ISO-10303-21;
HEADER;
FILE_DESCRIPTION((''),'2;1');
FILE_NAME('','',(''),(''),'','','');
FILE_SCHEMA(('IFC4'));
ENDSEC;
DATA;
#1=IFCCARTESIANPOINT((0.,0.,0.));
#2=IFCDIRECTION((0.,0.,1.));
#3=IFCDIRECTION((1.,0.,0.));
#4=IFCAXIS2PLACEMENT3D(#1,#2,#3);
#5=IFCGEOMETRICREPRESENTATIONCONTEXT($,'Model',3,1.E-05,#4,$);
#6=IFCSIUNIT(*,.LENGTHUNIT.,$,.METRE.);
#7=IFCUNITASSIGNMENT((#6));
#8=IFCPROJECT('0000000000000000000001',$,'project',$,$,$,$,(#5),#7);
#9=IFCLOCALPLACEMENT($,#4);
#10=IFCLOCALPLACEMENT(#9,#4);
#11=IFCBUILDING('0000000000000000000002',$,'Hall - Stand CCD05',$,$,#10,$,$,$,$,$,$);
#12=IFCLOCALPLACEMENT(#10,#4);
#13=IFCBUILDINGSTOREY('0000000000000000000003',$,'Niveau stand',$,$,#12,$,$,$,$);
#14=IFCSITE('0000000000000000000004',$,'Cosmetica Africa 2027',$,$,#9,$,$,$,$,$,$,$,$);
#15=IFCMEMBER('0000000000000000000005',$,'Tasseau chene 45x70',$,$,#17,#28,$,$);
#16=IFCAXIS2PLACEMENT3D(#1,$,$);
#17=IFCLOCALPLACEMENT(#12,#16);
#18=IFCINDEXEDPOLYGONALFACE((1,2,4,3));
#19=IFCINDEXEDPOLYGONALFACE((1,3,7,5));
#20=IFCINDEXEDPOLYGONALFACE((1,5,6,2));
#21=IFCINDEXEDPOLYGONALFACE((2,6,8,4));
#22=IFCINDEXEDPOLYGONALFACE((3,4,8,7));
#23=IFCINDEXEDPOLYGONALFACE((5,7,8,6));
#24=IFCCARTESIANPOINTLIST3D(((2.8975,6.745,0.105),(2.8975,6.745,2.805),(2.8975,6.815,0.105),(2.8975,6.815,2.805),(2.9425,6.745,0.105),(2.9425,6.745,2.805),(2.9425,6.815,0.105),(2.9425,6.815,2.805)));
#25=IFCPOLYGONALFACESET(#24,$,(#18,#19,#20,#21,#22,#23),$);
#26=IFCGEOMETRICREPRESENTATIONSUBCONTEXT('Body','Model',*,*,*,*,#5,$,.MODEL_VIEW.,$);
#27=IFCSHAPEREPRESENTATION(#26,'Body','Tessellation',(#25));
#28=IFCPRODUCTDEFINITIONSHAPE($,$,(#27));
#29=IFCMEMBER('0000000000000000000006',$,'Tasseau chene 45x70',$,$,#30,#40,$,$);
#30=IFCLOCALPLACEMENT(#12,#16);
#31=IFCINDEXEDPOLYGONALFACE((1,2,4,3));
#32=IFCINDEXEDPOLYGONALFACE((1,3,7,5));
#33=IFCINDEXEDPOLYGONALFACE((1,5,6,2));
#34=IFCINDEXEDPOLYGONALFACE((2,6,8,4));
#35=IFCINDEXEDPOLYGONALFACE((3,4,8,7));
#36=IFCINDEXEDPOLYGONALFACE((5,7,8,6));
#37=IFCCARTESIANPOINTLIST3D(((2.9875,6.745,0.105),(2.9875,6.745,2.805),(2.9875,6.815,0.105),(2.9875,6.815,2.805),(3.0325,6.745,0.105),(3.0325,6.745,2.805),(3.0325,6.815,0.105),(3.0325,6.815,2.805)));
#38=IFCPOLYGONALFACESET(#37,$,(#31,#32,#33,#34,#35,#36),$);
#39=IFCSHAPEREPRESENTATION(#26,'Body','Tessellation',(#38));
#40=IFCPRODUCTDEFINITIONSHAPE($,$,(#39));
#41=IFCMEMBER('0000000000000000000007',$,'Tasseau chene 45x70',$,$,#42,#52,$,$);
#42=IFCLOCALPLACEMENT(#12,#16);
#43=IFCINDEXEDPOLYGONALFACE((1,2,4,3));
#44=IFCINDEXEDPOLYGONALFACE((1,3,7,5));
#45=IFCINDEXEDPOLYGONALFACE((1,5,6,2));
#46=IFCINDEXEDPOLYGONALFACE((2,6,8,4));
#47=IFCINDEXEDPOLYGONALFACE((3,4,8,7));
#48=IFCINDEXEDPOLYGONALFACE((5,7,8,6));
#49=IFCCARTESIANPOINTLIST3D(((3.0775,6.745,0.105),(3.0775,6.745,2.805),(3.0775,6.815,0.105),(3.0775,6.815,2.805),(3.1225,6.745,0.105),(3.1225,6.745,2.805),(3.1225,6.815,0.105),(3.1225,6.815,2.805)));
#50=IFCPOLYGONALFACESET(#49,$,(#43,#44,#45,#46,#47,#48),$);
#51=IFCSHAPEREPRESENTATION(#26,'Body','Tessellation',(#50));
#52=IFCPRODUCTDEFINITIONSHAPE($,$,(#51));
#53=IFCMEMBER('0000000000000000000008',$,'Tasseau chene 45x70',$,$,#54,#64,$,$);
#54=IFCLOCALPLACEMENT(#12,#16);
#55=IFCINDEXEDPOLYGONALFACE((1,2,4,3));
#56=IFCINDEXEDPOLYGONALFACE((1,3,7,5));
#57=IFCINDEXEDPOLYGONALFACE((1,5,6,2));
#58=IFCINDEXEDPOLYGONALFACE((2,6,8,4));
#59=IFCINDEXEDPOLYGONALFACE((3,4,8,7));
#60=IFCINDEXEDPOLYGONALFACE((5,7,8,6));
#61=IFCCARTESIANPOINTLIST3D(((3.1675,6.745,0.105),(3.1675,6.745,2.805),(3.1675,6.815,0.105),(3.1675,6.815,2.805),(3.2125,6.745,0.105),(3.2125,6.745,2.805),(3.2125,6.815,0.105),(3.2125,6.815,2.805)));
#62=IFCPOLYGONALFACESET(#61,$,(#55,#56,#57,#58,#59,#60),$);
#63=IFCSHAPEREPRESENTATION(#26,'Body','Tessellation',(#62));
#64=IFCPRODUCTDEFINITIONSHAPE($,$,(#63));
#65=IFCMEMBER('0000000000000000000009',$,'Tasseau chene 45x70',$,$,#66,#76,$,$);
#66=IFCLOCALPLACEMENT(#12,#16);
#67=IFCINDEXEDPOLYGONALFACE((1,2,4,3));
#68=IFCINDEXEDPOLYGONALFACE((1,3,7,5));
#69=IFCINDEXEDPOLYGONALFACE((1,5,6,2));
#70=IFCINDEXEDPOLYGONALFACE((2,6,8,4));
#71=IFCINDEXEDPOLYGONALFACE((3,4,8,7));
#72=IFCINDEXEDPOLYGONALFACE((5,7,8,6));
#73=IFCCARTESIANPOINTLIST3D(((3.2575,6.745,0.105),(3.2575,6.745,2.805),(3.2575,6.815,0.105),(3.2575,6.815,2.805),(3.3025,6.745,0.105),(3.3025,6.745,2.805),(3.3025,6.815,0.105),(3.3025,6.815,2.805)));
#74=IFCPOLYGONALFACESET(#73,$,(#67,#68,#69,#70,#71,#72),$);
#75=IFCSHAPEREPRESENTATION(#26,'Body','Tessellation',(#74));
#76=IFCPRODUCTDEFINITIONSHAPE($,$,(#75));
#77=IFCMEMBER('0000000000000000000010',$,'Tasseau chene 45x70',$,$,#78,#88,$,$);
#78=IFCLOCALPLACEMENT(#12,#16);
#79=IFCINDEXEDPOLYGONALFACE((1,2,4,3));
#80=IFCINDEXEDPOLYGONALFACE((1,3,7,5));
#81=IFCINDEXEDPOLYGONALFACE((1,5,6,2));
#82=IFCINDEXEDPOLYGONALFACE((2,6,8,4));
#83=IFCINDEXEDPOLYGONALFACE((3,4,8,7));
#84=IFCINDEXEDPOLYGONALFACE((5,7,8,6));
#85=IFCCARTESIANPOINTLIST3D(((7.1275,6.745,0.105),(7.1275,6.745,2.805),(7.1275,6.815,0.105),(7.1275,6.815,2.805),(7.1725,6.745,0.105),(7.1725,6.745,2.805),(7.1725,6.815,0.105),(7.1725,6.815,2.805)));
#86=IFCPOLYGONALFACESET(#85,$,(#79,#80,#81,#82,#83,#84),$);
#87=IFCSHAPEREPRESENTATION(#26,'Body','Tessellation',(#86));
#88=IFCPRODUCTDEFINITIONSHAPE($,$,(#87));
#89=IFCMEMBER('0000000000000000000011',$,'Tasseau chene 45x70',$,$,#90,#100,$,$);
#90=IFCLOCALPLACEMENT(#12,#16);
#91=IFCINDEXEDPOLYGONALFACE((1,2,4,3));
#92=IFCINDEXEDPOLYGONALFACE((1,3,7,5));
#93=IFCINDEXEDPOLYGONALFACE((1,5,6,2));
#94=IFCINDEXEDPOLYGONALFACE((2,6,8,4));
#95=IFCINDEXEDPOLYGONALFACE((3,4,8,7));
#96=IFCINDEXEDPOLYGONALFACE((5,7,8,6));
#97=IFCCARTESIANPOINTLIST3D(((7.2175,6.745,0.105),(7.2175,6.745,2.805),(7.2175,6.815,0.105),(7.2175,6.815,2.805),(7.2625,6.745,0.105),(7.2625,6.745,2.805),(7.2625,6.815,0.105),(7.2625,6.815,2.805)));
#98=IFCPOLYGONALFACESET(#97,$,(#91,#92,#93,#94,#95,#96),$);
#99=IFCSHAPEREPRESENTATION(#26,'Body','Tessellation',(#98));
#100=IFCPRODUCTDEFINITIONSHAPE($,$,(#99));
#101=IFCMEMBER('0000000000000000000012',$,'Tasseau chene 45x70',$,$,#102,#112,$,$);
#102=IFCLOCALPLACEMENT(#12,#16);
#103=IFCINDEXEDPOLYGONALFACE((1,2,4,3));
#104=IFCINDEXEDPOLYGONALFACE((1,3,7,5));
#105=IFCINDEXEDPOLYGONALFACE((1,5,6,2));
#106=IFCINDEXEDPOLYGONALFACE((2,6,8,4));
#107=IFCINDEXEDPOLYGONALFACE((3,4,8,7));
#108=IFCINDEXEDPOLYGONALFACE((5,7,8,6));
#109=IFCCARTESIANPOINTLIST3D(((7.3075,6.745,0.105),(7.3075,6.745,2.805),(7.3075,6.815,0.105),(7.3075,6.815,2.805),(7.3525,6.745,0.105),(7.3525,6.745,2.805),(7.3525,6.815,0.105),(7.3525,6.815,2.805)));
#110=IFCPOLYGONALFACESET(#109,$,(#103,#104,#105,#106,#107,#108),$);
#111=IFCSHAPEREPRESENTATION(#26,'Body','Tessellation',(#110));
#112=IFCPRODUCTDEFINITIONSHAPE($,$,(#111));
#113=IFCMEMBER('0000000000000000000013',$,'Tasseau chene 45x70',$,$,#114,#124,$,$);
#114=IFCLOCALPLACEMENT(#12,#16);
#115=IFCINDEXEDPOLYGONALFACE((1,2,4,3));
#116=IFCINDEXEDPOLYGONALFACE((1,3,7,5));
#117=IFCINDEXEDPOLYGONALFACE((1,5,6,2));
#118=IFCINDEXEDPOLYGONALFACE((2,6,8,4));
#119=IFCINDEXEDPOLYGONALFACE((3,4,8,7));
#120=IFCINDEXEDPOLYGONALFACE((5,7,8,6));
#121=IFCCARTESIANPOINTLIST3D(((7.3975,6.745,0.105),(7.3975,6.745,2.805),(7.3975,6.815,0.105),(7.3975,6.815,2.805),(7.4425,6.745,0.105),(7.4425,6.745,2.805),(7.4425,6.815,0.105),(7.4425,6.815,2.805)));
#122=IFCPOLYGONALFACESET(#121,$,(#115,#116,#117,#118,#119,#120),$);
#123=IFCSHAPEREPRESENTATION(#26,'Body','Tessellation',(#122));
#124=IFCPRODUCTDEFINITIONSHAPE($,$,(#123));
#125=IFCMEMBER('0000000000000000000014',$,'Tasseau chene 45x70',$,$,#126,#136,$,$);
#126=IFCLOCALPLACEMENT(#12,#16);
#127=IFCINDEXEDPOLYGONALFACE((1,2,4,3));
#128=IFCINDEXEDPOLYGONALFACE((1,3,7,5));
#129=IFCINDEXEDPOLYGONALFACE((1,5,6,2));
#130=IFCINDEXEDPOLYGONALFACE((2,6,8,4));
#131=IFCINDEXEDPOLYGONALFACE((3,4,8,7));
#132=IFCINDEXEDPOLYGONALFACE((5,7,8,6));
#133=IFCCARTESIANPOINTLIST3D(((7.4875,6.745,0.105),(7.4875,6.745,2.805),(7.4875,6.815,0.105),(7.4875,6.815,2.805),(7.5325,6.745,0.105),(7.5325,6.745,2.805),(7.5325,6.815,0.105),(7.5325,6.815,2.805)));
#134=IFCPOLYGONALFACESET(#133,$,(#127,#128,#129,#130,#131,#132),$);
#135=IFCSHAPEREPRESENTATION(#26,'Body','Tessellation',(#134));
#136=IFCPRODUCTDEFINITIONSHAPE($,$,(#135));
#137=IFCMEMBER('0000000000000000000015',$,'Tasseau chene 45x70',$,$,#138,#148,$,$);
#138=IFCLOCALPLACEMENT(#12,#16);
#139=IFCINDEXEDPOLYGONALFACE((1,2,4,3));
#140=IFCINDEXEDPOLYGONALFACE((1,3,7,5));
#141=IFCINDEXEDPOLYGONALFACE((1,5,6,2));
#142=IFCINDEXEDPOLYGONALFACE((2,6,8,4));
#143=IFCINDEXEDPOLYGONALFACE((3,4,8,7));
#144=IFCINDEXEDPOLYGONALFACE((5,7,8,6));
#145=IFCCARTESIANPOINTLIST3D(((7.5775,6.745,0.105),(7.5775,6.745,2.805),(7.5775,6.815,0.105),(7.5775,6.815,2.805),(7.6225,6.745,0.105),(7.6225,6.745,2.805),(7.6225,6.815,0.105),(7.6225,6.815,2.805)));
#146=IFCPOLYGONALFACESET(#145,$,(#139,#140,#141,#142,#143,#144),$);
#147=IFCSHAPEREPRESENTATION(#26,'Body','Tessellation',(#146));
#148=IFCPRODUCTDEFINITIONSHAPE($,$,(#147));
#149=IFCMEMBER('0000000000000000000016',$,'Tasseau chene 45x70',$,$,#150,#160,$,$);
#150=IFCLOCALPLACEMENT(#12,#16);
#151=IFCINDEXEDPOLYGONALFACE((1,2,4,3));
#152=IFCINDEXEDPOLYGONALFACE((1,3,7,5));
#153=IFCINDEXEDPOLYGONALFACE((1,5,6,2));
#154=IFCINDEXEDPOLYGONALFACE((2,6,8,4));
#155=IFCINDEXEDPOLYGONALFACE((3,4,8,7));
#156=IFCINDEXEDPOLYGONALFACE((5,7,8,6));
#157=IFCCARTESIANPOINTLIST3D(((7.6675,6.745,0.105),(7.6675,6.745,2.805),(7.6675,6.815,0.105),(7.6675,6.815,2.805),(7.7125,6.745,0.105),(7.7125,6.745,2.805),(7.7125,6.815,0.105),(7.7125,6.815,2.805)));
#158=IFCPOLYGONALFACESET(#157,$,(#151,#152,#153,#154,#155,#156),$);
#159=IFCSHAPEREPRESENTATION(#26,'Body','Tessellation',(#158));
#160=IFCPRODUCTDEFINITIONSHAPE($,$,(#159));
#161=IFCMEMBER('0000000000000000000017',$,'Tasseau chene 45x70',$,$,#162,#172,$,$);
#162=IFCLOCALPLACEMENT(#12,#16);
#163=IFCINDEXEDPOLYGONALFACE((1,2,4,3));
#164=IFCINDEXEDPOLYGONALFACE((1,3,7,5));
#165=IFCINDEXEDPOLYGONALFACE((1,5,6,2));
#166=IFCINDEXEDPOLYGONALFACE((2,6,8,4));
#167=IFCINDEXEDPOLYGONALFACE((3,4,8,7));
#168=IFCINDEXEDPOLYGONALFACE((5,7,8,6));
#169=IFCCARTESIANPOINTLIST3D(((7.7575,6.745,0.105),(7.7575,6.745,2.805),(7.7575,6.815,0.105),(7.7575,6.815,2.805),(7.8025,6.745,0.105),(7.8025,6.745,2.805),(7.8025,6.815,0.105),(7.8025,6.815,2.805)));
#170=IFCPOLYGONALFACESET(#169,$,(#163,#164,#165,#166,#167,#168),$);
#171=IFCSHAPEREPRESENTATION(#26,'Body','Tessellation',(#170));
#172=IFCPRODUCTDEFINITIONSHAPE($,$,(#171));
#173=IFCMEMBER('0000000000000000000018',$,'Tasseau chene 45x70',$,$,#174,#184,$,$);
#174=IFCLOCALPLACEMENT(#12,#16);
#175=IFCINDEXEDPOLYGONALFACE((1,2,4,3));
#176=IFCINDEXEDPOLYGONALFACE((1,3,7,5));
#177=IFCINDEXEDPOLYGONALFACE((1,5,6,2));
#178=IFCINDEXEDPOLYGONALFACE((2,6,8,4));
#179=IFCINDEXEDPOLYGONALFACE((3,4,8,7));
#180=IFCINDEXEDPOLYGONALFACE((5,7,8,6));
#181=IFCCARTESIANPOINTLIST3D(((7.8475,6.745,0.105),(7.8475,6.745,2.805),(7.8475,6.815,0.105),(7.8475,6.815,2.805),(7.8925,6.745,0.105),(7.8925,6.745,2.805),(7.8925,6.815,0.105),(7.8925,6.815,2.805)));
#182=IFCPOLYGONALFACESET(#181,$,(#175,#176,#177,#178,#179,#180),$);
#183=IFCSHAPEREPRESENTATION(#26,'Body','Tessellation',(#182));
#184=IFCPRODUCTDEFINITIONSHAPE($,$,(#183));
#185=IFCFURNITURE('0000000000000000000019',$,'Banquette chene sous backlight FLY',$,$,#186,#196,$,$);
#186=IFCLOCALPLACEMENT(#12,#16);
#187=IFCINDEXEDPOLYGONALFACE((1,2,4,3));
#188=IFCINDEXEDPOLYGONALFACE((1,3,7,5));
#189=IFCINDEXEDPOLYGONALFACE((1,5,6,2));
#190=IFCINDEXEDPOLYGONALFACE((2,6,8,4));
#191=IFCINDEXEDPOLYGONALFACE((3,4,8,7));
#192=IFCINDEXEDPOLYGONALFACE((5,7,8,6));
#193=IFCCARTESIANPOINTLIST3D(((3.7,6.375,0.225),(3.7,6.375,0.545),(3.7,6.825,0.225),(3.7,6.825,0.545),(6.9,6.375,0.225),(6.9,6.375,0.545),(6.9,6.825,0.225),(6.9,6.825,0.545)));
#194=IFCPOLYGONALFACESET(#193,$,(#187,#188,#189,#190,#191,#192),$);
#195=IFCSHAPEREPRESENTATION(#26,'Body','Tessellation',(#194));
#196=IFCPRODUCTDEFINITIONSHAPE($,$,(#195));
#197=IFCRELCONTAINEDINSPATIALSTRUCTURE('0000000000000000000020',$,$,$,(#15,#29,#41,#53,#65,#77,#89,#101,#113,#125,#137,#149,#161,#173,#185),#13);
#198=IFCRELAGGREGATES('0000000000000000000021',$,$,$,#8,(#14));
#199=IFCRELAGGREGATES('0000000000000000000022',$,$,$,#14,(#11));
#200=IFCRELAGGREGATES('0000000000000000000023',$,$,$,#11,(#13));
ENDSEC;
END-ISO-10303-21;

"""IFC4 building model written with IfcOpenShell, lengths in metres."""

from ifc_helpers import new_model, si_unit, frame, origin_with_axes, place, context, subcontext, project, spatial, polyline, outline, extrude, element, save


model = new_model("IFC4")

# Units and contexts
model_context = context("Model", 3, precision=1e-05, world=origin_with_axes())
body_context = subcontext(model_context, "Body", "Model", "MODEL_VIEW")
ifc_project = project(units=[si_unit("LENGTHUNIT", "METRE")], contexts=[model_context])

# Site, building, storey
site_placement = place(None, origin_with_axes())
site = spatial("IfcSite", under=ifc_project, at=site_placement, Name="Cosmetica Africa 2027")
building_placement = place(site_placement, origin_with_axes())
building = spatial("IfcBuilding", under=site, at=building_placement, Name="Hall - Stand CCD05")
storey_placement = place(building_placement, origin_with_axes())
storey = spatial("IfcBuildingStorey", under=building, at=storey_placement, Name="Niveau stand")

# Members
member_1_placement = place(storey_placement, origin_with_axes())
element("IfcMember", 1, at=member_1_placement, inside=storey, Name="Tasseau chene 45x70", context=body_context, shape_type="SweptSolid", body=[
    extrude(outline(polyline([(2.8975, 6.745), (2.9425, 6.745), (2.9425, 6.815), (2.8975, 6.815), (2.8975, 6.745)])), frame((0.0, 0.0, 0.105)), (0.0, 0.0, 1.0), 2.7),
])
member_2_placement = place(storey_placement, origin_with_axes())
element("IfcMember", 2, at=member_2_placement, inside=storey, Name="Tasseau chene 45x70", context=body_context, shape_type="SweptSolid", body=[
    extrude(outline(polyline([(2.9875, 6.745), (3.0325, 6.745), (3.0325, 6.815), (2.9875, 6.815), (2.9875, 6.745)])), frame((0.0, 0.0, 0.105)), (0.0, 0.0, 1.0), 2.7),
])
member_3_placement = place(storey_placement, origin_with_axes())
element("IfcMember", 3, at=member_3_placement, inside=storey, Name="Tasseau chene 45x70", context=body_context, shape_type="SweptSolid", body=[
    extrude(outline(polyline([(3.0775, 6.745), (3.1225, 6.745), (3.1225, 6.815), (3.0775, 6.815), (3.0775, 6.745)])), frame((0.0, 0.0, 0.105)), (0.0, 0.0, 1.0), 2.7),
])
member_4_placement = place(storey_placement, origin_with_axes())
element("IfcMember", 4, at=member_4_placement, inside=storey, Name="Tasseau chene 45x70", context=body_context, shape_type="SweptSolid", body=[
    extrude(outline(polyline([(3.1675, 6.745), (3.2125, 6.745), (3.2125, 6.815), (3.1675, 6.815), (3.1675, 6.745)])), frame((0.0, 0.0, 0.105)), (0.0, 0.0, 1.0), 2.7),
])
member_5_placement = place(storey_placement, origin_with_axes())
element("IfcMember", 5, at=member_5_placement, inside=storey, Name="Tasseau chene 45x70", context=body_context, shape_type="SweptSolid", body=[
    extrude(outline(polyline([(3.2575, 6.745), (3.3025, 6.745), (3.3025, 6.815), (3.2575, 6.815), (3.2575, 6.745)])), frame((0.0, 0.0, 0.105)), (0.0, 0.0, 1.0), 2.7),
])
member_6_placement = place(storey_placement, origin_with_axes())
element("IfcMember", 6, at=member_6_placement, inside=storey, Name="Tasseau chene 45x70", context=body_context, shape_type="SweptSolid", body=[
    extrude(outline(polyline([(7.1275, 6.745), (7.1725, 6.745), (7.1725, 6.815), (7.1275, 6.815), (7.1275, 6.745)])), frame((0.0, 0.0, 0.105)), (0.0, 0.0, 1.0), 2.7),
])
member_7_placement = place(storey_placement, origin_with_axes())
element("IfcMember", 7, at=member_7_placement, inside=storey, Name="Tasseau chene 45x70", context=body_context, shape_type="SweptSolid", body=[
    extrude(outline(polyline([(7.2175, 6.745), (7.2625, 6.745), (7.2625, 6.815), (7.2175, 6.815), (7.2175, 6.745)])), frame((0.0, 0.0, 0.105)), (0.0, 0.0, 1.0), 2.7),
])
member_8_placement = place(storey_placement, origin_with_axes())
element("IfcMember", 8, at=member_8_placement, inside=storey, Name="Tasseau chene 45x70", context=body_context, shape_type="SweptSolid", body=[
    extrude(outline(polyline([(7.3075, 6.745), (7.3525, 6.745), (7.3525, 6.815), (7.3075, 6.815), (7.3075, 6.745)])), frame((0.0, 0.0, 0.105)), (0.0, 0.0, 1.0), 2.7),
])
member_9_placement = place(storey_placement, origin_with_axes())
element("IfcMember", 9, at=member_9_placement, inside=storey, Name="Tasseau chene 45x70", context=body_context, shape_type="SweptSolid", body=[
    extrude(outline(polyline([(7.3975, 6.745), (7.4425, 6.745), (7.4425, 6.815), (7.3975, 6.815), (7.3975, 6.745)])), frame((0.0, 0.0, 0.105)), (0.0, 0.0, 1.0), 2.7),
])
member_10_placement = place(storey_placement, origin_with_axes())
element("IfcMember", 10, at=member_10_placement, inside=storey, Name="Tasseau chene 45x70", context=body_context, shape_type="SweptSolid", body=[
    extrude(outline(polyline([(7.4875, 6.745), (7.5325, 6.745), (7.5325, 6.815), (7.4875, 6.815), (7.4875, 6.745)])), frame((0.0, 0.0, 0.105)), (0.0, 0.0, 1.0), 2.7),
])
member_11_placement = place(storey_placement, origin_with_axes())
element("IfcMember", 11, at=member_11_placement, inside=storey, Name="Tasseau chene 45x70", context=body_context, shape_type="SweptSolid", body=[
    extrude(outline(polyline([(7.5775, 6.745), (7.6225, 6.745), (7.6225, 6.815), (7.5775, 6.815), (7.5775, 6.745)])), frame((0.0, 0.0, 0.105)), (0.0, 0.0, 1.0), 2.7),
])
member_12_placement = place(storey_placement, origin_with_axes())
element("IfcMember", 12, at=member_12_placement, inside=storey, Name="Tasseau chene 45x70", context=body_context, shape_type="SweptSolid", body=[
    extrude(outline(polyline([(7.6675, 6.745), (7.7125, 6.745), (7.7125, 6.815), (7.6675, 6.815), (7.6675, 6.745)])), frame((0.0, 0.0, 0.105)), (0.0, 0.0, 1.0), 2.7),
])
member_13_placement = place(storey_placement, origin_with_axes())
element("IfcMember", 13, at=member_13_placement, inside=storey, Name="Tasseau chene 45x70", context=body_context, shape_type="SweptSolid", body=[
    extrude(outline(polyline([(7.7575, 6.745), (7.8025, 6.745), (7.8025, 6.815), (7.7575, 6.815), (7.7575, 6.745)])), frame((0.0, 0.0, 0.105)), (0.0, 0.0, 1.0), 2.7),
])
member_14_placement = place(storey_placement, origin_with_axes())
element("IfcMember", 14, at=member_14_placement, inside=storey, Name="Tasseau chene 45x70", context=body_context, shape_type="SweptSolid", body=[
    extrude(outline(polyline([(7.8475, 6.745), (7.8925, 6.745), (7.8925, 6.815), (7.8475, 6.815), (7.8475, 6.745)])), frame((0.0, 0.0, 0.105)), (0.0, 0.0, 1.0), 2.7),
])

# Furniture
furniture_1_placement = place(storey_placement, origin_with_axes())
element("IfcFurniture", 15, at=furniture_1_placement, inside=storey, Name="Banquette chene sous backlight FLY", context=body_context, shape_type="SweptSolid", body=[
    extrude(outline(polyline([(3.7, 6.375), (6.9, 6.375), (6.9, 6.825), (3.7, 6.825), (3.7, 6.375)])), frame((0.0, 0.0, 0.225)), (0.0, 0.0, 1.0), 0.32),
])

save(model, "model.ifc")
